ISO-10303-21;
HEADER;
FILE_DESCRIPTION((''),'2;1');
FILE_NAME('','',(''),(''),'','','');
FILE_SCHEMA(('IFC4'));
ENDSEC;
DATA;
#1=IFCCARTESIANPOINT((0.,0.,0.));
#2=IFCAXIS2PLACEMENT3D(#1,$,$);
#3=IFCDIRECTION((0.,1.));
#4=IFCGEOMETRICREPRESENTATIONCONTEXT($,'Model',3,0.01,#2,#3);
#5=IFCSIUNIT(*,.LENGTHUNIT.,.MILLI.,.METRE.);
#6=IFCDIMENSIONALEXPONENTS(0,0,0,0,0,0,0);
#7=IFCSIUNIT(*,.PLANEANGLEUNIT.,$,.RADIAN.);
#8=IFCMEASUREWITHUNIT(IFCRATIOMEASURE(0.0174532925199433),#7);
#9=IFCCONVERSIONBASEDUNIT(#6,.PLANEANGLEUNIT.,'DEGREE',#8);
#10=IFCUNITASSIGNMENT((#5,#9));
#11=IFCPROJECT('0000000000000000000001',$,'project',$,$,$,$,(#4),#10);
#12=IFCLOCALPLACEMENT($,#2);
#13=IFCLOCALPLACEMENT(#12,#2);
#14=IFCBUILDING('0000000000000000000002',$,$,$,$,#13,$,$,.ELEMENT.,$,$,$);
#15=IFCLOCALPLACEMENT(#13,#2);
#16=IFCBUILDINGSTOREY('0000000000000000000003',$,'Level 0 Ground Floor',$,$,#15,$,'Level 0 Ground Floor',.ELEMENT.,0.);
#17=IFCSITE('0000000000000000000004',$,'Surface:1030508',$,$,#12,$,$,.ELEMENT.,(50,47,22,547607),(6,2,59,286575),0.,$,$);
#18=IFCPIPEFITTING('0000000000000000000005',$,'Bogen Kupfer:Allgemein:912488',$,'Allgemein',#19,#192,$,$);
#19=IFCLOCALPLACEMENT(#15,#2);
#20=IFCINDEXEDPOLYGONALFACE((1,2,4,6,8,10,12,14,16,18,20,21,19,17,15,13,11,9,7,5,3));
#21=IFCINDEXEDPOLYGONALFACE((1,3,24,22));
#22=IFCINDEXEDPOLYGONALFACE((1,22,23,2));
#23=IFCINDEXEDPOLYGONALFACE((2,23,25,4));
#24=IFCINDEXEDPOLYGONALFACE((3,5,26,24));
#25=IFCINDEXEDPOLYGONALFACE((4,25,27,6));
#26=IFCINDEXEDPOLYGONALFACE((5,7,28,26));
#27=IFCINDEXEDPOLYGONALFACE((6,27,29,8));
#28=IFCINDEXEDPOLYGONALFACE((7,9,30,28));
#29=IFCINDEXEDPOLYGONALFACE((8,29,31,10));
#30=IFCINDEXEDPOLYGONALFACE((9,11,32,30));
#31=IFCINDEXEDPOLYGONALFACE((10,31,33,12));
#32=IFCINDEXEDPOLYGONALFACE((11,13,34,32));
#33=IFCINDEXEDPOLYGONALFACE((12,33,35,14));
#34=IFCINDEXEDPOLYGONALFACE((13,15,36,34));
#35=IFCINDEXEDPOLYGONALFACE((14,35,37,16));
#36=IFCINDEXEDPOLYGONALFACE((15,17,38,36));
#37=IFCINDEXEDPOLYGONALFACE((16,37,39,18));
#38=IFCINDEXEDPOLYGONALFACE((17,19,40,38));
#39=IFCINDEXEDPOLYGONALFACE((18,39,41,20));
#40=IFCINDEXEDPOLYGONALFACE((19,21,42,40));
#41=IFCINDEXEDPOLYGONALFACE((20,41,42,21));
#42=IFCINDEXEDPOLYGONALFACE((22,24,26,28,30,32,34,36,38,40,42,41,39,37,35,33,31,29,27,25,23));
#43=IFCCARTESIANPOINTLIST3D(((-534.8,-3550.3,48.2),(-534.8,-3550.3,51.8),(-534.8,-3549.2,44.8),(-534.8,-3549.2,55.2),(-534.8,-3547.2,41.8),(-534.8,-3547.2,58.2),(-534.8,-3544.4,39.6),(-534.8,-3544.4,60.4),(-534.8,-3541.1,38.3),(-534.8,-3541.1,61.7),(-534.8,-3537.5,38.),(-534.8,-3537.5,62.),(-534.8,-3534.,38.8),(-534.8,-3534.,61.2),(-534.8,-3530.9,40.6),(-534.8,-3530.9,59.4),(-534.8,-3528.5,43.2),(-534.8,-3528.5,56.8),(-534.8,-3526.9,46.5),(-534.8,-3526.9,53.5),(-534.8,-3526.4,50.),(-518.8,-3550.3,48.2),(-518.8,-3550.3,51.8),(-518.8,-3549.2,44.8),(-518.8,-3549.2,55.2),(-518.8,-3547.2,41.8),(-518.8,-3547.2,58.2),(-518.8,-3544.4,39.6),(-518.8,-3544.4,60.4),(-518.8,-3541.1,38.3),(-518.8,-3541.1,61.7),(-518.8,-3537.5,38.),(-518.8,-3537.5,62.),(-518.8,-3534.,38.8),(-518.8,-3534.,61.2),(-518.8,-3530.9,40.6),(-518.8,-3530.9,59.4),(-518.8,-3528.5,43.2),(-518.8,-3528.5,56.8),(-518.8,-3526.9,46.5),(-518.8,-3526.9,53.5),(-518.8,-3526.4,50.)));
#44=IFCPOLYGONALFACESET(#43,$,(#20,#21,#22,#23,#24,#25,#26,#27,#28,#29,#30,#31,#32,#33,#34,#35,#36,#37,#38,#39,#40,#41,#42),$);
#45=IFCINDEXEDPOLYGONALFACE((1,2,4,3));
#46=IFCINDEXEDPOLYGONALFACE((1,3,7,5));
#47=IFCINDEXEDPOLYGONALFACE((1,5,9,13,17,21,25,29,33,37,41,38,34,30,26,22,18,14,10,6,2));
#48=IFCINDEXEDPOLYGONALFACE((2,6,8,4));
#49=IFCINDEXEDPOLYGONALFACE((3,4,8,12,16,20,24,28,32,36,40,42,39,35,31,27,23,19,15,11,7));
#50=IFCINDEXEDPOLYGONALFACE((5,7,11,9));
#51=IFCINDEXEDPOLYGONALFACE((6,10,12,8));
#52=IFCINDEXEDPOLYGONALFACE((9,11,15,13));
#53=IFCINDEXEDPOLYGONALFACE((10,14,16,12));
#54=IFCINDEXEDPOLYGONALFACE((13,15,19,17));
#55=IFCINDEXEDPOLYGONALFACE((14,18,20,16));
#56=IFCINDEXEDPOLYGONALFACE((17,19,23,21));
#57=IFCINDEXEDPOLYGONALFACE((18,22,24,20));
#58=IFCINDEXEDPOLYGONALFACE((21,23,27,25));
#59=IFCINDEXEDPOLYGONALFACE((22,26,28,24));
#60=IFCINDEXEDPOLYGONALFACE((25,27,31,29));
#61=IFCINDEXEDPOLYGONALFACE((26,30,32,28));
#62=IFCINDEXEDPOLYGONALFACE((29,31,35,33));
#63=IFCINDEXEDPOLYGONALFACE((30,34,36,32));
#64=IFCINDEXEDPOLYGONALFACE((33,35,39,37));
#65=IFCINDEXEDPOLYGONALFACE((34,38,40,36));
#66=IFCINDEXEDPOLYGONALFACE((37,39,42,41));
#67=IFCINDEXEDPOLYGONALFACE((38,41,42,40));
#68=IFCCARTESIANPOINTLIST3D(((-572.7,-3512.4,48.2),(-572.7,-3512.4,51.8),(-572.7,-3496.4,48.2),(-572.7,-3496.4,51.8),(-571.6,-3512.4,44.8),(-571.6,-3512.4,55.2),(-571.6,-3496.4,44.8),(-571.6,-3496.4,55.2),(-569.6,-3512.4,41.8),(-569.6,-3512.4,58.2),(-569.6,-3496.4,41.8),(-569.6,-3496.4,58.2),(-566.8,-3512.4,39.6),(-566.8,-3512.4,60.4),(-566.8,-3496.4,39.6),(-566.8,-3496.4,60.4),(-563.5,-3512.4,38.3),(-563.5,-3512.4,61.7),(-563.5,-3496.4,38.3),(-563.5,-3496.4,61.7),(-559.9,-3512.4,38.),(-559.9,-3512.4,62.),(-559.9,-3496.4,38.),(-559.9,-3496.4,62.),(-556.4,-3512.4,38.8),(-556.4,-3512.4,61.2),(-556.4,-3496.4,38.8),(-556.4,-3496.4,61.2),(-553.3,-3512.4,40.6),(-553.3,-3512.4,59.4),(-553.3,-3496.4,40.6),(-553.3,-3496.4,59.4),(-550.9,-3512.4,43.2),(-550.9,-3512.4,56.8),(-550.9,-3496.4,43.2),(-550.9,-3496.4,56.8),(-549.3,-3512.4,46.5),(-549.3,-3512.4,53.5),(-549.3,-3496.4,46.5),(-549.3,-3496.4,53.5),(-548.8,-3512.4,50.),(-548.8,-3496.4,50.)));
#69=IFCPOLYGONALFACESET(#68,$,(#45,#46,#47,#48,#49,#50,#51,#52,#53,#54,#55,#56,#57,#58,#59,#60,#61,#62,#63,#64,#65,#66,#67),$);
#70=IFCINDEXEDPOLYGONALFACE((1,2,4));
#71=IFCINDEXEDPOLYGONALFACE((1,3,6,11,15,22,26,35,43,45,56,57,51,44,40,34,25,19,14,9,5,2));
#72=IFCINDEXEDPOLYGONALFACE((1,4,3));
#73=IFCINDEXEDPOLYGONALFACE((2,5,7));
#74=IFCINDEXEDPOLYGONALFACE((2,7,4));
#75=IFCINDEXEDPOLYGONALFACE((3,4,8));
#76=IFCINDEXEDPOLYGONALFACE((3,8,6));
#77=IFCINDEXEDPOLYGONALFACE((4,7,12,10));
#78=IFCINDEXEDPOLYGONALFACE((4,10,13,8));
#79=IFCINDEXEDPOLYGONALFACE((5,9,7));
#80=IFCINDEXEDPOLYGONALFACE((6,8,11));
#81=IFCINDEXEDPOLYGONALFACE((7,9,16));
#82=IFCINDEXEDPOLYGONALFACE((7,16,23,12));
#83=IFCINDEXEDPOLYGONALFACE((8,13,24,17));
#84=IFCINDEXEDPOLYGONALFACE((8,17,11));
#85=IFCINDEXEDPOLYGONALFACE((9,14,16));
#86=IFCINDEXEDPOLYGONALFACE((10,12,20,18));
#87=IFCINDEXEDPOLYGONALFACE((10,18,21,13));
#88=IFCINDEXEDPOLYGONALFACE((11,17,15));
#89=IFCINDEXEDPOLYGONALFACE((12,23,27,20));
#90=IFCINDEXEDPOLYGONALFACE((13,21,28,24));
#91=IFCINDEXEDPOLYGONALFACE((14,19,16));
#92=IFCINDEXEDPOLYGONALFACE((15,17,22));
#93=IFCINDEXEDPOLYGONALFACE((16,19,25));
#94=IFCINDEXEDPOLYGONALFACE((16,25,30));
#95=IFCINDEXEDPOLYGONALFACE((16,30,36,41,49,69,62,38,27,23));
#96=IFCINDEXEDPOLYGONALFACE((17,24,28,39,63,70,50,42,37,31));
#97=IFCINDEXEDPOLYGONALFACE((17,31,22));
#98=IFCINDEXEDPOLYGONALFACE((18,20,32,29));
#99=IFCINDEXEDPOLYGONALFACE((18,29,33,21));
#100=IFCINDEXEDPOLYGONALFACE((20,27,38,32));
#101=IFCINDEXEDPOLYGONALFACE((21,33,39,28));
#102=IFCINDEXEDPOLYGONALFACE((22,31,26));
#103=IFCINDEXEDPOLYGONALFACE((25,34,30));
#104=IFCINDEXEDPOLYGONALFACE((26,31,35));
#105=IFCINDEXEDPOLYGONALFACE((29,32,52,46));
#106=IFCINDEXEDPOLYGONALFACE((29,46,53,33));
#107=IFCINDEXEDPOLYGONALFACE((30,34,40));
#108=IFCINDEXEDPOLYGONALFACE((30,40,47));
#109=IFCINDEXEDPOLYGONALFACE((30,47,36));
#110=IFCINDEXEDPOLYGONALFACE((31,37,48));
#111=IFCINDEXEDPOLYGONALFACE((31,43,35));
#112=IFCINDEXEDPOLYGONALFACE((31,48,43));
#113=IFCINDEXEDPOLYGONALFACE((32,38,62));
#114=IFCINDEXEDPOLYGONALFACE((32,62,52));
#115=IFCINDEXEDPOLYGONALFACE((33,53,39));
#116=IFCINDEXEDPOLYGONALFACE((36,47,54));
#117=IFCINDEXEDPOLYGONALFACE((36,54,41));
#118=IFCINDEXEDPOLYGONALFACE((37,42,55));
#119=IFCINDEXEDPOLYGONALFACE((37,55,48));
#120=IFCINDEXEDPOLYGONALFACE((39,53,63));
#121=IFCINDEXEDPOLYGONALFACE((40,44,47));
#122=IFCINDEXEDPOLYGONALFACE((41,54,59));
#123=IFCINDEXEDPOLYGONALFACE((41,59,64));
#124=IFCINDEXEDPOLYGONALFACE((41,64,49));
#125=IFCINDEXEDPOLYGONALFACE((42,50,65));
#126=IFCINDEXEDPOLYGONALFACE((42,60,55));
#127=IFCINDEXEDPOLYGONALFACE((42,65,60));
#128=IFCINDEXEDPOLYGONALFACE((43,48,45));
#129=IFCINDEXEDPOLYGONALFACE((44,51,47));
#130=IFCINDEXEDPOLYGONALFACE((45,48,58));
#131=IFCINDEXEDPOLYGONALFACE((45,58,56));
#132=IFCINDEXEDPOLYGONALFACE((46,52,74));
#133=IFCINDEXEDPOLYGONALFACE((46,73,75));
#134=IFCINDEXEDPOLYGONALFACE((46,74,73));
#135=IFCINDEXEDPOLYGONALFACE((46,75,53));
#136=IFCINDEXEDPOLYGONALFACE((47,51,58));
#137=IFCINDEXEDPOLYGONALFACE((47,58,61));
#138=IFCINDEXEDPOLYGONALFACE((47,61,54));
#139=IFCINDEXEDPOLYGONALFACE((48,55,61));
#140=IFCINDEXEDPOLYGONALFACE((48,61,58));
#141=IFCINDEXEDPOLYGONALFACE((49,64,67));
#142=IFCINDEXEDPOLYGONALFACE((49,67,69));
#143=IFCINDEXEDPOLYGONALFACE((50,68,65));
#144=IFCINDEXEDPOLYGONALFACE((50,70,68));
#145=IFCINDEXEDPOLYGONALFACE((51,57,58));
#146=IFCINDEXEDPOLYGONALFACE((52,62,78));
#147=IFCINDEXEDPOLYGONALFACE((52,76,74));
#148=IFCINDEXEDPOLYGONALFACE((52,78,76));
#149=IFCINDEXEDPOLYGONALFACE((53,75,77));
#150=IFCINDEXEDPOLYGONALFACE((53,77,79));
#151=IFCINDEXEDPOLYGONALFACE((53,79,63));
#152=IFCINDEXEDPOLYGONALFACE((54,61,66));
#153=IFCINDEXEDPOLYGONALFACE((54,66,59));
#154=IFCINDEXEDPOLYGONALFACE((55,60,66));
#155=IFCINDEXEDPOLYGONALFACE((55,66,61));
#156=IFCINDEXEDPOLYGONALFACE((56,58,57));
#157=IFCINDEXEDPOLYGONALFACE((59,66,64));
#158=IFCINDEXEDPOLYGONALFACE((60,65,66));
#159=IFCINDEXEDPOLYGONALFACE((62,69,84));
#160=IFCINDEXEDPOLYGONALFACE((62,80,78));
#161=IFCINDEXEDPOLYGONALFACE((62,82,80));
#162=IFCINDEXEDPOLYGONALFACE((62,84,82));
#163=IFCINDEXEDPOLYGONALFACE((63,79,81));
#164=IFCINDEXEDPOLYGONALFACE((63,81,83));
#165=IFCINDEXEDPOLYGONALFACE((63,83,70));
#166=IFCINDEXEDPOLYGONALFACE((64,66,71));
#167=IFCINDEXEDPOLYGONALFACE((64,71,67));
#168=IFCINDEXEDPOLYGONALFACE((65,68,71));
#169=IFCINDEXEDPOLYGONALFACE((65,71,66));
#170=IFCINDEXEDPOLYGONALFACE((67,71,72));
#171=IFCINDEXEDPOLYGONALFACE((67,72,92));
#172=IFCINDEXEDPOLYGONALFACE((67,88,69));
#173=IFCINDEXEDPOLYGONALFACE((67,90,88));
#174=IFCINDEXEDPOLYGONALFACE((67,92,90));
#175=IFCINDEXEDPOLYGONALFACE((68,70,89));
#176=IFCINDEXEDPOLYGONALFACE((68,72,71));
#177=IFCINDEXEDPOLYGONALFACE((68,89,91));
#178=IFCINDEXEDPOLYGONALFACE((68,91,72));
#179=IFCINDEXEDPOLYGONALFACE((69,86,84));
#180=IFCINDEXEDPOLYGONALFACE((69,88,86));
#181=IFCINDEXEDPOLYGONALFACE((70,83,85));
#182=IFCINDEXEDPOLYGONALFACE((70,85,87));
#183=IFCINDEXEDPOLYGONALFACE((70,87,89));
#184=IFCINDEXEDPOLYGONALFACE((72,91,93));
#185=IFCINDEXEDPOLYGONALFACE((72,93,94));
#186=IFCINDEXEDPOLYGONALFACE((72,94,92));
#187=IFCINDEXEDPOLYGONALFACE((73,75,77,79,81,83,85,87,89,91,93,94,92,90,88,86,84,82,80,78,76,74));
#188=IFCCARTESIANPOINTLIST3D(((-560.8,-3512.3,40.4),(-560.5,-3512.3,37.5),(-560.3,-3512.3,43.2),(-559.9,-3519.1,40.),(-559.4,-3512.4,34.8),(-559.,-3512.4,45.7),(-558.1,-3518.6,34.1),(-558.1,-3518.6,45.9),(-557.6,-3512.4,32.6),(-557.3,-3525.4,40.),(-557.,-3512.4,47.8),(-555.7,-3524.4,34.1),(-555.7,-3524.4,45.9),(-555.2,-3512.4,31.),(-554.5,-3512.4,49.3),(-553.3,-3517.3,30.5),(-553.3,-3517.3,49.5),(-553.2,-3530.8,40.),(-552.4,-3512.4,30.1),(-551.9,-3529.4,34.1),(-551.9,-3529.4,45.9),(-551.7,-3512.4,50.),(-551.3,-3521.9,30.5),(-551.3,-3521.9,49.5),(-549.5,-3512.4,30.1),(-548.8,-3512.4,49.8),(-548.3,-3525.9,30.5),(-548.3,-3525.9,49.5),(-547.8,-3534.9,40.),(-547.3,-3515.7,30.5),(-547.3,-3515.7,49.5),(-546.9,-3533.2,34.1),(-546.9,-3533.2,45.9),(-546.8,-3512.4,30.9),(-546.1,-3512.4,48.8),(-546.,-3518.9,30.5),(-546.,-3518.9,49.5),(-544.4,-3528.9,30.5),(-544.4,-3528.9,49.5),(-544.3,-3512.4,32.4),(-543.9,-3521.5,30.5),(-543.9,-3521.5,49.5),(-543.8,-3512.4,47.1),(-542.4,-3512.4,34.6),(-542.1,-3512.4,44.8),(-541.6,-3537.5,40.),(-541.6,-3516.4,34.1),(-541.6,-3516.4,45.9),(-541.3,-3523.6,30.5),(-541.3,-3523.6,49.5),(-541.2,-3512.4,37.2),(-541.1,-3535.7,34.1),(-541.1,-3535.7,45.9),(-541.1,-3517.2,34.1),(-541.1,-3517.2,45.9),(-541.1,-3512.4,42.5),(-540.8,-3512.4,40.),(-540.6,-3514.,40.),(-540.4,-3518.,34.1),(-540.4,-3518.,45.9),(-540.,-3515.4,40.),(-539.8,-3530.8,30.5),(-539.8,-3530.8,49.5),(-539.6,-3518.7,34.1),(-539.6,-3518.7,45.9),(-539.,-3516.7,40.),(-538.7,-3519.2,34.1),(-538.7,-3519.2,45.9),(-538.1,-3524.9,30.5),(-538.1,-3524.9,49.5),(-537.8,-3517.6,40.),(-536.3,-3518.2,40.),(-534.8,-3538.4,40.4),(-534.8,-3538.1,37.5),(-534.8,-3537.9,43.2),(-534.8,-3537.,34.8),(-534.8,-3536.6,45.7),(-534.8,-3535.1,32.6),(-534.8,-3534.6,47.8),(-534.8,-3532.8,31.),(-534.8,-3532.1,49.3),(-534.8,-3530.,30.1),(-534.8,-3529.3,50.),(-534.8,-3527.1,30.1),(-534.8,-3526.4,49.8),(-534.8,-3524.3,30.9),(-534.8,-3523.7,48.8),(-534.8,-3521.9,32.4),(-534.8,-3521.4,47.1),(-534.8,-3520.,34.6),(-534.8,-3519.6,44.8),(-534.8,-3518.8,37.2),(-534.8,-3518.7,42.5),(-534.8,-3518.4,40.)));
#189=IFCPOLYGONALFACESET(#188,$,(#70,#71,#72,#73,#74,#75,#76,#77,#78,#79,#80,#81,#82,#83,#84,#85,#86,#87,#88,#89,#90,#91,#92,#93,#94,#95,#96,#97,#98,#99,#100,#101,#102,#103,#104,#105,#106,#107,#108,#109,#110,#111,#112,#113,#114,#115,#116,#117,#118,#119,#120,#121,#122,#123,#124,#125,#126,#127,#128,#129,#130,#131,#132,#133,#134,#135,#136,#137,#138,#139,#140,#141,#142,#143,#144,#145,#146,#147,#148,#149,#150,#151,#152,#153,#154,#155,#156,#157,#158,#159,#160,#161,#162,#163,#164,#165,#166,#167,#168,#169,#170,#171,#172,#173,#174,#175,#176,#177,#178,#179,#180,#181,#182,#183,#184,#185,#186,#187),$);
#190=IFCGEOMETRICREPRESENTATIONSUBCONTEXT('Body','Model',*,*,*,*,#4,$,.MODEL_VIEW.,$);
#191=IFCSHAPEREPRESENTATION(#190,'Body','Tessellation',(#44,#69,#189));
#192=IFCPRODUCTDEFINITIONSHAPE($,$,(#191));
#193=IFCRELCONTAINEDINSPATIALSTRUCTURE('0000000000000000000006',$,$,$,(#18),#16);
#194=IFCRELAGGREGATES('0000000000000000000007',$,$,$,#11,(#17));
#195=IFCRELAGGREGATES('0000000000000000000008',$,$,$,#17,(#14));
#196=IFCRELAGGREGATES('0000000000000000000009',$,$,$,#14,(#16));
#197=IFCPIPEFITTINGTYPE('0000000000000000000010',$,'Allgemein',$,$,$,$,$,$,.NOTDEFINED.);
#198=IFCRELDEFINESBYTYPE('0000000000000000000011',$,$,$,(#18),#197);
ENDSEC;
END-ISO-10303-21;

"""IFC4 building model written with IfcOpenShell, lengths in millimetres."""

from ifc_helpers import new_model, entity, si_unit, converted_unit, direction, frame, frame_2d, origin, place, context, subcontext, project, spatial, circle, extrude, source, transform, mapped, type_object, type_shapes, element, save


model = new_model("IFC4")

# Units and contexts
model_context = context("Model", 3, precision=0.01, world=origin(), true_north=direction((0.0, 1.0)))
body_context = subcontext(model_context, "Body", "Model", "MODEL_VIEW")
ifc_project = project(units=[si_unit("LENGTHUNIT", "METRE", prefix="MILLI"), converted_unit("PLANEANGLEUNIT", "DEGREE", entity("IfcRatioMeasure", 0.0174532925199433), si_unit("PLANEANGLEUNIT", "RADIAN"), dimensions=[0, 0, 0, 0, 0, 0, 0])], contexts=[model_context])

# Site, building, storey
site_placement = place(None, origin())
site = spatial("IfcSite", under=ifc_project, at=site_placement, Name="Surface:1030508", CompositionType="ELEMENT", RefLatitude=(50, 47, 22, 547607), RefLongitude=(6, 2, 59, 286575), RefElevation=0.0)
building_placement = place(site_placement, origin())
building = spatial("IfcBuilding", under=site, at=building_placement, CompositionType="ELEMENT")
storey_placement = place(building_placement, origin())
storey = spatial("IfcBuildingStorey", under=building, at=storey_placement, Name="Level 0 Ground Floor", LongName="Level 0 Ground Floor", CompositionType="ELEMENT", Elevation=0.0)

# Pipe fitting
pipe_fitting_type_1 = type_object("IfcPipeFittingType", Name="Allgemein", PredefinedType="NOTDEFINED")
ifc_direction_1 = entity("IfcDirection", [0.0, 0.0, -1.0])
trimmed_curve_1 = entity("IfcTrimmedCurve", entity("IfcCircle", entity("IfcAxis2Placement2D", entity("IfcCartesianPoint", [-16.0, 0.0]), entity("IfcDirection", [0.0, 1.0])), 16.0), [entity("IfcParameterValue", 270.0)], [entity("IfcParameterValue", 0.0)], True, "PARAMETER")
shared_shape_1 = source(origin(), body_context, "Body", "SolidModel", [
    extrude(circle(Radius=12.0, at=frame_2d((0.0, 0.0), x_axis=(1.0, 0.0))), frame((0.0, 26.0, 0.0), z_axis=(0.0, 1.0, 0.0), x_axis=(-1.0, 0.0, 0.0)), (0.0, 0.0, 1.0), 16.0),
    extrude(circle(Radius=12.0, at=frame_2d((0.0, 0.0), x_axis=(1.0, 0.0))), frame((-42.0, 0.0, 0.0), z_axis=(1.0, 0.0, 0.0), x_axis=(0.0, 1.0, 0.0)), (0.0, 0.0, 1.0), 16.0),
    entity("IfcSurfaceCurveSweptAreaSolid", entity("IfcCircleProfileDef", "AREA", None, entity("IfcAxis2Placement2D", entity("IfcCartesianPoint", [0.0, 10.0]), entity("IfcDirection", [1.0, 0.0])), 10.0), entity("IfcAxis2Placement3D", entity("IfcCartesianPoint", [-10.0, 26.0, 0.0]), ifc_direction_1, entity("IfcDirection", [1.0, 0.0, 0.0])), trimmed_curve_1, 0.0, 90.0, entity("IfcSurfaceOfLinearExtrusion", entity("IfcArbitraryOpenProfileDef", "CURVE", None, trimmed_curve_1), entity("IfcAxis2Placement3D", entity("IfcCartesianPoint", [0.0, 0.0, -304.8])), ifc_direction_1, 1.0)),
])
type_shapes(pipe_fitting_type_1, [shared_shape_1])
for number, where, z_axis, x_axis, name in (
    (1, (-560.8, -3538.4, 50.0), (0.0, 0.0, 1.0), (0.0, -1.0, 0.0), "Bogen Kupfer:Allgemein:912488"),
):
    element("IfcPipeFitting", number, at=place(storey_placement, frame(where, z_axis=z_axis, x_axis=x_axis)), inside=storey, type_object=pipe_fitting_type_1, Name=name, ObjectType="Allgemein", context=body_context, shape_type="MappedRepresentation", body=[
        mapped(shared_shape_1, transform((0.0, 0.0, 0.0), scale=1.0)),
    ])

save(model, "model.ifc")
